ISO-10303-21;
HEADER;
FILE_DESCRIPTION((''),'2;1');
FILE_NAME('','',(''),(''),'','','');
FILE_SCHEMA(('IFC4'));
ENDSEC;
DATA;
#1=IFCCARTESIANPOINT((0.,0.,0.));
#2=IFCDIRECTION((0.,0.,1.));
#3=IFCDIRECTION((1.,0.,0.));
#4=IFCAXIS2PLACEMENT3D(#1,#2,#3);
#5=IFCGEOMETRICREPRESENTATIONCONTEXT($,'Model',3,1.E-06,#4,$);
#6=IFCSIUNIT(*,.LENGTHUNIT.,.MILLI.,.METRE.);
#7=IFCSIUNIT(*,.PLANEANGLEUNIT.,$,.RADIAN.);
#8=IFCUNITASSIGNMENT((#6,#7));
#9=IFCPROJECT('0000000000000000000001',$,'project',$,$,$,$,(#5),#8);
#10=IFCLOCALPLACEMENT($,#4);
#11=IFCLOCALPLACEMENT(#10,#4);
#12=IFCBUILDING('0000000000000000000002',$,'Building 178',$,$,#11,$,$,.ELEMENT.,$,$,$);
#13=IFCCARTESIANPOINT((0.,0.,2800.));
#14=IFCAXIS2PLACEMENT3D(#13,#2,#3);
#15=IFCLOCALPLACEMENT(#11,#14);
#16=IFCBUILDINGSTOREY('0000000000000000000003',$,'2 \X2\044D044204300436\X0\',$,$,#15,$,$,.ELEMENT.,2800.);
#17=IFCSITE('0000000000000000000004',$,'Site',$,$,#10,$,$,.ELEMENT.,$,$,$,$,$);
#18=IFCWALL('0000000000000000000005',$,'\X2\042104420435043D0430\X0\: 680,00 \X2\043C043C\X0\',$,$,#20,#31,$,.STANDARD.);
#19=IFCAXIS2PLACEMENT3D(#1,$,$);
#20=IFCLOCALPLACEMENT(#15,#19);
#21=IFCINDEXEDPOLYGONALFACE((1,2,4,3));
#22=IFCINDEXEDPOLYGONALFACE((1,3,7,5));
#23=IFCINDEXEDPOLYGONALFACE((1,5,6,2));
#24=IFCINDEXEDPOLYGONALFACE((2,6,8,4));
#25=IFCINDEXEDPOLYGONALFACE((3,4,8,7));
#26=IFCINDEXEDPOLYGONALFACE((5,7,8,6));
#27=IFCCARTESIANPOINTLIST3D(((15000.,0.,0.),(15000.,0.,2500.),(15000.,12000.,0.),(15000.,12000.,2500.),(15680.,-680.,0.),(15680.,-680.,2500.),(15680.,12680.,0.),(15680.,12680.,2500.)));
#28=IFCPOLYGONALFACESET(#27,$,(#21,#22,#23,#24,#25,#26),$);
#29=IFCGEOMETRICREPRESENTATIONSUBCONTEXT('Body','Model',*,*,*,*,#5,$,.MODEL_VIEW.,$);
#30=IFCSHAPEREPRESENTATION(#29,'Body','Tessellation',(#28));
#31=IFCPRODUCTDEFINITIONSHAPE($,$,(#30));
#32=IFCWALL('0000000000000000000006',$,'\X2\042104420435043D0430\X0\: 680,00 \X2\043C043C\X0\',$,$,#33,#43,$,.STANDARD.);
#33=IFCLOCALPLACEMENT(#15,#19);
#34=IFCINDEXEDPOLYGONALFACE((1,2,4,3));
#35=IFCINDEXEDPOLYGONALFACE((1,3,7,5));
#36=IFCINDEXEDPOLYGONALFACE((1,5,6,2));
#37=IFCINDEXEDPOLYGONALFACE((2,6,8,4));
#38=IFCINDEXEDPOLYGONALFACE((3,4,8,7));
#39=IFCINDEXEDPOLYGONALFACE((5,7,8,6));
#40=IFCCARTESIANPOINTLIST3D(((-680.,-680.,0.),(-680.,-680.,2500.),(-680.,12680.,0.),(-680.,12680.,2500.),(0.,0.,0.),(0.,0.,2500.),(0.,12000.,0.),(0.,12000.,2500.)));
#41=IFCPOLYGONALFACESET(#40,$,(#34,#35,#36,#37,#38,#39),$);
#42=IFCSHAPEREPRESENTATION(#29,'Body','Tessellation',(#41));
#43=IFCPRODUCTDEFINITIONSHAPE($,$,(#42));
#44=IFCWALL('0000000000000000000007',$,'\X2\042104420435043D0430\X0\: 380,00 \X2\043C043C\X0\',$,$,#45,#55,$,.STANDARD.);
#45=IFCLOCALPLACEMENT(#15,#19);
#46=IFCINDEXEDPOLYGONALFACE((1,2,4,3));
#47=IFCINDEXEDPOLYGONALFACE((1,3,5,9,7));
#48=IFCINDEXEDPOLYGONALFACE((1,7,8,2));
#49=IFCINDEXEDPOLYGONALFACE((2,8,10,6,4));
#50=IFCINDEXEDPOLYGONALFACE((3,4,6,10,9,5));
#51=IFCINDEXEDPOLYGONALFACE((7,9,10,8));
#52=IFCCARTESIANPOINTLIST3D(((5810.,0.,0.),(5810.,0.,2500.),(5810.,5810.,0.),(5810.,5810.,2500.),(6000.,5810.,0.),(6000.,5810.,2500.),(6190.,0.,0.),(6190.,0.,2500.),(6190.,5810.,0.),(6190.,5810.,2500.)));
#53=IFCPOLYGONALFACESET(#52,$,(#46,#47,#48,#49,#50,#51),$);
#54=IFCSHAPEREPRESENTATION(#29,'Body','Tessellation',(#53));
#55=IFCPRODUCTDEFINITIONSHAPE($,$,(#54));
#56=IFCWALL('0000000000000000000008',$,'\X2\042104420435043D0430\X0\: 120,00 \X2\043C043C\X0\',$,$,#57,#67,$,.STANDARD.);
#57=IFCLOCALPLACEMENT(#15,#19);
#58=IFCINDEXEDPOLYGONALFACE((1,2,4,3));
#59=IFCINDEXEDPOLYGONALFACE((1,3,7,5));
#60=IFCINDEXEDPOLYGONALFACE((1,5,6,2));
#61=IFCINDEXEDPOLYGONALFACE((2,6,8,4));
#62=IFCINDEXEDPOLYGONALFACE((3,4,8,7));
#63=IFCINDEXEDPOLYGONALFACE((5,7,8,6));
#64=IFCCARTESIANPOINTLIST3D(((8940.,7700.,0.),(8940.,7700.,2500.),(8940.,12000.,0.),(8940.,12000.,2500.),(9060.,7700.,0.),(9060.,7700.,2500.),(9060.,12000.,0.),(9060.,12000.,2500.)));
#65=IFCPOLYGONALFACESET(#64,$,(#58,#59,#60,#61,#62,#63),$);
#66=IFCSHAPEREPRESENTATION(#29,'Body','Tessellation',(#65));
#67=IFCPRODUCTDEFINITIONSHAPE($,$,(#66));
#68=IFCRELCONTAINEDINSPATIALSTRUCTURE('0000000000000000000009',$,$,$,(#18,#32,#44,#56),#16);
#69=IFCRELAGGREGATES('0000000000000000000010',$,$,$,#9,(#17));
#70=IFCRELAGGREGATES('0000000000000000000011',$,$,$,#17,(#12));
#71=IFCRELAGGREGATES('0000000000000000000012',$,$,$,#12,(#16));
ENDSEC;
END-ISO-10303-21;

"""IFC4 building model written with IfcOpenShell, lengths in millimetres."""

from ifc_helpers import new_model, si_unit, frame, origin_with_axes, place, context, subcontext, project, spatial, line, indexed_curve, outline, extrude, source, transform, mapped, element, save


model = new_model("IFC4")

# Units and contexts
model_context = context("Model", 3, precision=1e-06, world=origin_with_axes())
body_context = subcontext(model_context, "Body", "Model", "MODEL_VIEW")
ifc_project = project(units=[si_unit("LENGTHUNIT", "METRE", prefix="MILLI"), si_unit("PLANEANGLEUNIT", "RADIAN")], contexts=[model_context])

# Site, building, storey
site_placement = place(None, origin_with_axes())
site = spatial("IfcSite", under=ifc_project, at=site_placement, Name="Site", CompositionType="ELEMENT")
building_placement = place(site_placement, origin_with_axes())
building = spatial("IfcBuilding", under=site, at=building_placement, Name="Building 178", CompositionType="ELEMENT")
storey_placement = place(building_placement, frame((0.0, 0.0, 2800.0), z_axis=(0.0, 0.0, 1.0), x_axis=(1.0, 0.0, 0.0)))
storey = spatial("IfcBuildingStorey", under=building, at=storey_placement, Name="2 этаж", CompositionType="ELEMENT", Elevation=2800.0)

# Walls
shared_shape_1 = source(origin_with_axes(), body_context, "Body", "SweptSolid", [
    extrude(outline(indexed_curve([(-340.0, -340.0), (13020.0, -340.0), (12340.0, 340.0), (340.0, 340.0)], segments=[line(1, 2), line(2, 3), line(3, 4), line(4, 1)])), origin_with_axes(), (0.0, 0.0, 1.0), 2500.0),
])
for number, where, z_axis, x_axis, name in (
    (1, (15340.0, -340.0, 0.0), (0.0, 0.0, 1.0), (0.0, 1.0, 0.0), "Стена: 680,00 мм"),
    (2, (-340.0, 12340.0, 0.0), (0.0, 0.0, 1.0), (0.0, -1.0, 0.0), "Стена: 680,00 мм"),
):
    element("IfcWall", number, at=place(storey_placement, frame(where, z_axis=z_axis, x_axis=x_axis)), inside=storey, Name=name, PredefinedType="STANDARD", context=body_context, shape_type="MappedRepresentation", body=[
        mapped(shared_shape_1, transform((0.0, 0.0, 0.0), x_axis=(1.0, 0.0, 0.0), y_axis=(0.0, 1.0, 0.0), z_axis=(0.0, 0.0, 1.0), scale=1.0)),
    ])
shared_shape_2 = source(origin_with_axes(), body_context, "Body", "SweptSolid", [
    extrude(outline(indexed_curve([(0.0, -190.0), (5810.0, -190.0), (5810.0, 0.0), (5810.0, 190.0), (0.0, 190.0)], segments=[line(1, 2), line(2, 3), line(3, 4), line(4, 5), line(5, 1)])), origin_with_axes(), (0.0, 0.0, 1.0), 2500.0),
])
wall_1_placement = place(storey_placement, frame((6000.0, 0.0, 0.0), z_axis=(0.0, 0.0, 1.0), x_axis=(0.0, 1.0, 0.0)))
element("IfcWall", 3, at=wall_1_placement, inside=storey, Name="Стена: 380,00 мм", PredefinedType="STANDARD", context=body_context, shape_type="MappedRepresentation", body=[
    mapped(shared_shape_2, transform((0.0, 0.0, 0.0), x_axis=(1.0, 0.0, 0.0), y_axis=(0.0, 1.0, 0.0), z_axis=(0.0, 0.0, 1.0), scale=1.0)),
])
shared_shape_3 = source(origin_with_axes(), body_context, "Body", "SweptSolid", [
    extrude(outline(indexed_curve([(0.0, -60.0), (4300.0, -60.0), (4300.0, 60.0), (0.0, 60.0)], segments=[line(1, 2), line(2, 3), line(3, 4), line(4, 1)])), origin_with_axes(), (0.0, 0.0, 1.0), 2500.0),
])
wall_2_placement = place(storey_placement, frame((9000.0, 7700.0, 0.0), z_axis=(0.0, 0.0, 1.0), x_axis=(0.0, 1.0, 0.0)))
element("IfcWall", 4, at=wall_2_placement, inside=storey, Name="Стена: 120,00 мм", PredefinedType="STANDARD", context=body_context, shape_type="MappedRepresentation", body=[
    mapped(shared_shape_3, transform((0.0, 0.0, 0.0), x_axis=(1.0, 0.0, 0.0), y_axis=(0.0, 1.0, 0.0), z_axis=(0.0, 0.0, 1.0), scale=1.0)),
])

save(model, "model.ifc")
